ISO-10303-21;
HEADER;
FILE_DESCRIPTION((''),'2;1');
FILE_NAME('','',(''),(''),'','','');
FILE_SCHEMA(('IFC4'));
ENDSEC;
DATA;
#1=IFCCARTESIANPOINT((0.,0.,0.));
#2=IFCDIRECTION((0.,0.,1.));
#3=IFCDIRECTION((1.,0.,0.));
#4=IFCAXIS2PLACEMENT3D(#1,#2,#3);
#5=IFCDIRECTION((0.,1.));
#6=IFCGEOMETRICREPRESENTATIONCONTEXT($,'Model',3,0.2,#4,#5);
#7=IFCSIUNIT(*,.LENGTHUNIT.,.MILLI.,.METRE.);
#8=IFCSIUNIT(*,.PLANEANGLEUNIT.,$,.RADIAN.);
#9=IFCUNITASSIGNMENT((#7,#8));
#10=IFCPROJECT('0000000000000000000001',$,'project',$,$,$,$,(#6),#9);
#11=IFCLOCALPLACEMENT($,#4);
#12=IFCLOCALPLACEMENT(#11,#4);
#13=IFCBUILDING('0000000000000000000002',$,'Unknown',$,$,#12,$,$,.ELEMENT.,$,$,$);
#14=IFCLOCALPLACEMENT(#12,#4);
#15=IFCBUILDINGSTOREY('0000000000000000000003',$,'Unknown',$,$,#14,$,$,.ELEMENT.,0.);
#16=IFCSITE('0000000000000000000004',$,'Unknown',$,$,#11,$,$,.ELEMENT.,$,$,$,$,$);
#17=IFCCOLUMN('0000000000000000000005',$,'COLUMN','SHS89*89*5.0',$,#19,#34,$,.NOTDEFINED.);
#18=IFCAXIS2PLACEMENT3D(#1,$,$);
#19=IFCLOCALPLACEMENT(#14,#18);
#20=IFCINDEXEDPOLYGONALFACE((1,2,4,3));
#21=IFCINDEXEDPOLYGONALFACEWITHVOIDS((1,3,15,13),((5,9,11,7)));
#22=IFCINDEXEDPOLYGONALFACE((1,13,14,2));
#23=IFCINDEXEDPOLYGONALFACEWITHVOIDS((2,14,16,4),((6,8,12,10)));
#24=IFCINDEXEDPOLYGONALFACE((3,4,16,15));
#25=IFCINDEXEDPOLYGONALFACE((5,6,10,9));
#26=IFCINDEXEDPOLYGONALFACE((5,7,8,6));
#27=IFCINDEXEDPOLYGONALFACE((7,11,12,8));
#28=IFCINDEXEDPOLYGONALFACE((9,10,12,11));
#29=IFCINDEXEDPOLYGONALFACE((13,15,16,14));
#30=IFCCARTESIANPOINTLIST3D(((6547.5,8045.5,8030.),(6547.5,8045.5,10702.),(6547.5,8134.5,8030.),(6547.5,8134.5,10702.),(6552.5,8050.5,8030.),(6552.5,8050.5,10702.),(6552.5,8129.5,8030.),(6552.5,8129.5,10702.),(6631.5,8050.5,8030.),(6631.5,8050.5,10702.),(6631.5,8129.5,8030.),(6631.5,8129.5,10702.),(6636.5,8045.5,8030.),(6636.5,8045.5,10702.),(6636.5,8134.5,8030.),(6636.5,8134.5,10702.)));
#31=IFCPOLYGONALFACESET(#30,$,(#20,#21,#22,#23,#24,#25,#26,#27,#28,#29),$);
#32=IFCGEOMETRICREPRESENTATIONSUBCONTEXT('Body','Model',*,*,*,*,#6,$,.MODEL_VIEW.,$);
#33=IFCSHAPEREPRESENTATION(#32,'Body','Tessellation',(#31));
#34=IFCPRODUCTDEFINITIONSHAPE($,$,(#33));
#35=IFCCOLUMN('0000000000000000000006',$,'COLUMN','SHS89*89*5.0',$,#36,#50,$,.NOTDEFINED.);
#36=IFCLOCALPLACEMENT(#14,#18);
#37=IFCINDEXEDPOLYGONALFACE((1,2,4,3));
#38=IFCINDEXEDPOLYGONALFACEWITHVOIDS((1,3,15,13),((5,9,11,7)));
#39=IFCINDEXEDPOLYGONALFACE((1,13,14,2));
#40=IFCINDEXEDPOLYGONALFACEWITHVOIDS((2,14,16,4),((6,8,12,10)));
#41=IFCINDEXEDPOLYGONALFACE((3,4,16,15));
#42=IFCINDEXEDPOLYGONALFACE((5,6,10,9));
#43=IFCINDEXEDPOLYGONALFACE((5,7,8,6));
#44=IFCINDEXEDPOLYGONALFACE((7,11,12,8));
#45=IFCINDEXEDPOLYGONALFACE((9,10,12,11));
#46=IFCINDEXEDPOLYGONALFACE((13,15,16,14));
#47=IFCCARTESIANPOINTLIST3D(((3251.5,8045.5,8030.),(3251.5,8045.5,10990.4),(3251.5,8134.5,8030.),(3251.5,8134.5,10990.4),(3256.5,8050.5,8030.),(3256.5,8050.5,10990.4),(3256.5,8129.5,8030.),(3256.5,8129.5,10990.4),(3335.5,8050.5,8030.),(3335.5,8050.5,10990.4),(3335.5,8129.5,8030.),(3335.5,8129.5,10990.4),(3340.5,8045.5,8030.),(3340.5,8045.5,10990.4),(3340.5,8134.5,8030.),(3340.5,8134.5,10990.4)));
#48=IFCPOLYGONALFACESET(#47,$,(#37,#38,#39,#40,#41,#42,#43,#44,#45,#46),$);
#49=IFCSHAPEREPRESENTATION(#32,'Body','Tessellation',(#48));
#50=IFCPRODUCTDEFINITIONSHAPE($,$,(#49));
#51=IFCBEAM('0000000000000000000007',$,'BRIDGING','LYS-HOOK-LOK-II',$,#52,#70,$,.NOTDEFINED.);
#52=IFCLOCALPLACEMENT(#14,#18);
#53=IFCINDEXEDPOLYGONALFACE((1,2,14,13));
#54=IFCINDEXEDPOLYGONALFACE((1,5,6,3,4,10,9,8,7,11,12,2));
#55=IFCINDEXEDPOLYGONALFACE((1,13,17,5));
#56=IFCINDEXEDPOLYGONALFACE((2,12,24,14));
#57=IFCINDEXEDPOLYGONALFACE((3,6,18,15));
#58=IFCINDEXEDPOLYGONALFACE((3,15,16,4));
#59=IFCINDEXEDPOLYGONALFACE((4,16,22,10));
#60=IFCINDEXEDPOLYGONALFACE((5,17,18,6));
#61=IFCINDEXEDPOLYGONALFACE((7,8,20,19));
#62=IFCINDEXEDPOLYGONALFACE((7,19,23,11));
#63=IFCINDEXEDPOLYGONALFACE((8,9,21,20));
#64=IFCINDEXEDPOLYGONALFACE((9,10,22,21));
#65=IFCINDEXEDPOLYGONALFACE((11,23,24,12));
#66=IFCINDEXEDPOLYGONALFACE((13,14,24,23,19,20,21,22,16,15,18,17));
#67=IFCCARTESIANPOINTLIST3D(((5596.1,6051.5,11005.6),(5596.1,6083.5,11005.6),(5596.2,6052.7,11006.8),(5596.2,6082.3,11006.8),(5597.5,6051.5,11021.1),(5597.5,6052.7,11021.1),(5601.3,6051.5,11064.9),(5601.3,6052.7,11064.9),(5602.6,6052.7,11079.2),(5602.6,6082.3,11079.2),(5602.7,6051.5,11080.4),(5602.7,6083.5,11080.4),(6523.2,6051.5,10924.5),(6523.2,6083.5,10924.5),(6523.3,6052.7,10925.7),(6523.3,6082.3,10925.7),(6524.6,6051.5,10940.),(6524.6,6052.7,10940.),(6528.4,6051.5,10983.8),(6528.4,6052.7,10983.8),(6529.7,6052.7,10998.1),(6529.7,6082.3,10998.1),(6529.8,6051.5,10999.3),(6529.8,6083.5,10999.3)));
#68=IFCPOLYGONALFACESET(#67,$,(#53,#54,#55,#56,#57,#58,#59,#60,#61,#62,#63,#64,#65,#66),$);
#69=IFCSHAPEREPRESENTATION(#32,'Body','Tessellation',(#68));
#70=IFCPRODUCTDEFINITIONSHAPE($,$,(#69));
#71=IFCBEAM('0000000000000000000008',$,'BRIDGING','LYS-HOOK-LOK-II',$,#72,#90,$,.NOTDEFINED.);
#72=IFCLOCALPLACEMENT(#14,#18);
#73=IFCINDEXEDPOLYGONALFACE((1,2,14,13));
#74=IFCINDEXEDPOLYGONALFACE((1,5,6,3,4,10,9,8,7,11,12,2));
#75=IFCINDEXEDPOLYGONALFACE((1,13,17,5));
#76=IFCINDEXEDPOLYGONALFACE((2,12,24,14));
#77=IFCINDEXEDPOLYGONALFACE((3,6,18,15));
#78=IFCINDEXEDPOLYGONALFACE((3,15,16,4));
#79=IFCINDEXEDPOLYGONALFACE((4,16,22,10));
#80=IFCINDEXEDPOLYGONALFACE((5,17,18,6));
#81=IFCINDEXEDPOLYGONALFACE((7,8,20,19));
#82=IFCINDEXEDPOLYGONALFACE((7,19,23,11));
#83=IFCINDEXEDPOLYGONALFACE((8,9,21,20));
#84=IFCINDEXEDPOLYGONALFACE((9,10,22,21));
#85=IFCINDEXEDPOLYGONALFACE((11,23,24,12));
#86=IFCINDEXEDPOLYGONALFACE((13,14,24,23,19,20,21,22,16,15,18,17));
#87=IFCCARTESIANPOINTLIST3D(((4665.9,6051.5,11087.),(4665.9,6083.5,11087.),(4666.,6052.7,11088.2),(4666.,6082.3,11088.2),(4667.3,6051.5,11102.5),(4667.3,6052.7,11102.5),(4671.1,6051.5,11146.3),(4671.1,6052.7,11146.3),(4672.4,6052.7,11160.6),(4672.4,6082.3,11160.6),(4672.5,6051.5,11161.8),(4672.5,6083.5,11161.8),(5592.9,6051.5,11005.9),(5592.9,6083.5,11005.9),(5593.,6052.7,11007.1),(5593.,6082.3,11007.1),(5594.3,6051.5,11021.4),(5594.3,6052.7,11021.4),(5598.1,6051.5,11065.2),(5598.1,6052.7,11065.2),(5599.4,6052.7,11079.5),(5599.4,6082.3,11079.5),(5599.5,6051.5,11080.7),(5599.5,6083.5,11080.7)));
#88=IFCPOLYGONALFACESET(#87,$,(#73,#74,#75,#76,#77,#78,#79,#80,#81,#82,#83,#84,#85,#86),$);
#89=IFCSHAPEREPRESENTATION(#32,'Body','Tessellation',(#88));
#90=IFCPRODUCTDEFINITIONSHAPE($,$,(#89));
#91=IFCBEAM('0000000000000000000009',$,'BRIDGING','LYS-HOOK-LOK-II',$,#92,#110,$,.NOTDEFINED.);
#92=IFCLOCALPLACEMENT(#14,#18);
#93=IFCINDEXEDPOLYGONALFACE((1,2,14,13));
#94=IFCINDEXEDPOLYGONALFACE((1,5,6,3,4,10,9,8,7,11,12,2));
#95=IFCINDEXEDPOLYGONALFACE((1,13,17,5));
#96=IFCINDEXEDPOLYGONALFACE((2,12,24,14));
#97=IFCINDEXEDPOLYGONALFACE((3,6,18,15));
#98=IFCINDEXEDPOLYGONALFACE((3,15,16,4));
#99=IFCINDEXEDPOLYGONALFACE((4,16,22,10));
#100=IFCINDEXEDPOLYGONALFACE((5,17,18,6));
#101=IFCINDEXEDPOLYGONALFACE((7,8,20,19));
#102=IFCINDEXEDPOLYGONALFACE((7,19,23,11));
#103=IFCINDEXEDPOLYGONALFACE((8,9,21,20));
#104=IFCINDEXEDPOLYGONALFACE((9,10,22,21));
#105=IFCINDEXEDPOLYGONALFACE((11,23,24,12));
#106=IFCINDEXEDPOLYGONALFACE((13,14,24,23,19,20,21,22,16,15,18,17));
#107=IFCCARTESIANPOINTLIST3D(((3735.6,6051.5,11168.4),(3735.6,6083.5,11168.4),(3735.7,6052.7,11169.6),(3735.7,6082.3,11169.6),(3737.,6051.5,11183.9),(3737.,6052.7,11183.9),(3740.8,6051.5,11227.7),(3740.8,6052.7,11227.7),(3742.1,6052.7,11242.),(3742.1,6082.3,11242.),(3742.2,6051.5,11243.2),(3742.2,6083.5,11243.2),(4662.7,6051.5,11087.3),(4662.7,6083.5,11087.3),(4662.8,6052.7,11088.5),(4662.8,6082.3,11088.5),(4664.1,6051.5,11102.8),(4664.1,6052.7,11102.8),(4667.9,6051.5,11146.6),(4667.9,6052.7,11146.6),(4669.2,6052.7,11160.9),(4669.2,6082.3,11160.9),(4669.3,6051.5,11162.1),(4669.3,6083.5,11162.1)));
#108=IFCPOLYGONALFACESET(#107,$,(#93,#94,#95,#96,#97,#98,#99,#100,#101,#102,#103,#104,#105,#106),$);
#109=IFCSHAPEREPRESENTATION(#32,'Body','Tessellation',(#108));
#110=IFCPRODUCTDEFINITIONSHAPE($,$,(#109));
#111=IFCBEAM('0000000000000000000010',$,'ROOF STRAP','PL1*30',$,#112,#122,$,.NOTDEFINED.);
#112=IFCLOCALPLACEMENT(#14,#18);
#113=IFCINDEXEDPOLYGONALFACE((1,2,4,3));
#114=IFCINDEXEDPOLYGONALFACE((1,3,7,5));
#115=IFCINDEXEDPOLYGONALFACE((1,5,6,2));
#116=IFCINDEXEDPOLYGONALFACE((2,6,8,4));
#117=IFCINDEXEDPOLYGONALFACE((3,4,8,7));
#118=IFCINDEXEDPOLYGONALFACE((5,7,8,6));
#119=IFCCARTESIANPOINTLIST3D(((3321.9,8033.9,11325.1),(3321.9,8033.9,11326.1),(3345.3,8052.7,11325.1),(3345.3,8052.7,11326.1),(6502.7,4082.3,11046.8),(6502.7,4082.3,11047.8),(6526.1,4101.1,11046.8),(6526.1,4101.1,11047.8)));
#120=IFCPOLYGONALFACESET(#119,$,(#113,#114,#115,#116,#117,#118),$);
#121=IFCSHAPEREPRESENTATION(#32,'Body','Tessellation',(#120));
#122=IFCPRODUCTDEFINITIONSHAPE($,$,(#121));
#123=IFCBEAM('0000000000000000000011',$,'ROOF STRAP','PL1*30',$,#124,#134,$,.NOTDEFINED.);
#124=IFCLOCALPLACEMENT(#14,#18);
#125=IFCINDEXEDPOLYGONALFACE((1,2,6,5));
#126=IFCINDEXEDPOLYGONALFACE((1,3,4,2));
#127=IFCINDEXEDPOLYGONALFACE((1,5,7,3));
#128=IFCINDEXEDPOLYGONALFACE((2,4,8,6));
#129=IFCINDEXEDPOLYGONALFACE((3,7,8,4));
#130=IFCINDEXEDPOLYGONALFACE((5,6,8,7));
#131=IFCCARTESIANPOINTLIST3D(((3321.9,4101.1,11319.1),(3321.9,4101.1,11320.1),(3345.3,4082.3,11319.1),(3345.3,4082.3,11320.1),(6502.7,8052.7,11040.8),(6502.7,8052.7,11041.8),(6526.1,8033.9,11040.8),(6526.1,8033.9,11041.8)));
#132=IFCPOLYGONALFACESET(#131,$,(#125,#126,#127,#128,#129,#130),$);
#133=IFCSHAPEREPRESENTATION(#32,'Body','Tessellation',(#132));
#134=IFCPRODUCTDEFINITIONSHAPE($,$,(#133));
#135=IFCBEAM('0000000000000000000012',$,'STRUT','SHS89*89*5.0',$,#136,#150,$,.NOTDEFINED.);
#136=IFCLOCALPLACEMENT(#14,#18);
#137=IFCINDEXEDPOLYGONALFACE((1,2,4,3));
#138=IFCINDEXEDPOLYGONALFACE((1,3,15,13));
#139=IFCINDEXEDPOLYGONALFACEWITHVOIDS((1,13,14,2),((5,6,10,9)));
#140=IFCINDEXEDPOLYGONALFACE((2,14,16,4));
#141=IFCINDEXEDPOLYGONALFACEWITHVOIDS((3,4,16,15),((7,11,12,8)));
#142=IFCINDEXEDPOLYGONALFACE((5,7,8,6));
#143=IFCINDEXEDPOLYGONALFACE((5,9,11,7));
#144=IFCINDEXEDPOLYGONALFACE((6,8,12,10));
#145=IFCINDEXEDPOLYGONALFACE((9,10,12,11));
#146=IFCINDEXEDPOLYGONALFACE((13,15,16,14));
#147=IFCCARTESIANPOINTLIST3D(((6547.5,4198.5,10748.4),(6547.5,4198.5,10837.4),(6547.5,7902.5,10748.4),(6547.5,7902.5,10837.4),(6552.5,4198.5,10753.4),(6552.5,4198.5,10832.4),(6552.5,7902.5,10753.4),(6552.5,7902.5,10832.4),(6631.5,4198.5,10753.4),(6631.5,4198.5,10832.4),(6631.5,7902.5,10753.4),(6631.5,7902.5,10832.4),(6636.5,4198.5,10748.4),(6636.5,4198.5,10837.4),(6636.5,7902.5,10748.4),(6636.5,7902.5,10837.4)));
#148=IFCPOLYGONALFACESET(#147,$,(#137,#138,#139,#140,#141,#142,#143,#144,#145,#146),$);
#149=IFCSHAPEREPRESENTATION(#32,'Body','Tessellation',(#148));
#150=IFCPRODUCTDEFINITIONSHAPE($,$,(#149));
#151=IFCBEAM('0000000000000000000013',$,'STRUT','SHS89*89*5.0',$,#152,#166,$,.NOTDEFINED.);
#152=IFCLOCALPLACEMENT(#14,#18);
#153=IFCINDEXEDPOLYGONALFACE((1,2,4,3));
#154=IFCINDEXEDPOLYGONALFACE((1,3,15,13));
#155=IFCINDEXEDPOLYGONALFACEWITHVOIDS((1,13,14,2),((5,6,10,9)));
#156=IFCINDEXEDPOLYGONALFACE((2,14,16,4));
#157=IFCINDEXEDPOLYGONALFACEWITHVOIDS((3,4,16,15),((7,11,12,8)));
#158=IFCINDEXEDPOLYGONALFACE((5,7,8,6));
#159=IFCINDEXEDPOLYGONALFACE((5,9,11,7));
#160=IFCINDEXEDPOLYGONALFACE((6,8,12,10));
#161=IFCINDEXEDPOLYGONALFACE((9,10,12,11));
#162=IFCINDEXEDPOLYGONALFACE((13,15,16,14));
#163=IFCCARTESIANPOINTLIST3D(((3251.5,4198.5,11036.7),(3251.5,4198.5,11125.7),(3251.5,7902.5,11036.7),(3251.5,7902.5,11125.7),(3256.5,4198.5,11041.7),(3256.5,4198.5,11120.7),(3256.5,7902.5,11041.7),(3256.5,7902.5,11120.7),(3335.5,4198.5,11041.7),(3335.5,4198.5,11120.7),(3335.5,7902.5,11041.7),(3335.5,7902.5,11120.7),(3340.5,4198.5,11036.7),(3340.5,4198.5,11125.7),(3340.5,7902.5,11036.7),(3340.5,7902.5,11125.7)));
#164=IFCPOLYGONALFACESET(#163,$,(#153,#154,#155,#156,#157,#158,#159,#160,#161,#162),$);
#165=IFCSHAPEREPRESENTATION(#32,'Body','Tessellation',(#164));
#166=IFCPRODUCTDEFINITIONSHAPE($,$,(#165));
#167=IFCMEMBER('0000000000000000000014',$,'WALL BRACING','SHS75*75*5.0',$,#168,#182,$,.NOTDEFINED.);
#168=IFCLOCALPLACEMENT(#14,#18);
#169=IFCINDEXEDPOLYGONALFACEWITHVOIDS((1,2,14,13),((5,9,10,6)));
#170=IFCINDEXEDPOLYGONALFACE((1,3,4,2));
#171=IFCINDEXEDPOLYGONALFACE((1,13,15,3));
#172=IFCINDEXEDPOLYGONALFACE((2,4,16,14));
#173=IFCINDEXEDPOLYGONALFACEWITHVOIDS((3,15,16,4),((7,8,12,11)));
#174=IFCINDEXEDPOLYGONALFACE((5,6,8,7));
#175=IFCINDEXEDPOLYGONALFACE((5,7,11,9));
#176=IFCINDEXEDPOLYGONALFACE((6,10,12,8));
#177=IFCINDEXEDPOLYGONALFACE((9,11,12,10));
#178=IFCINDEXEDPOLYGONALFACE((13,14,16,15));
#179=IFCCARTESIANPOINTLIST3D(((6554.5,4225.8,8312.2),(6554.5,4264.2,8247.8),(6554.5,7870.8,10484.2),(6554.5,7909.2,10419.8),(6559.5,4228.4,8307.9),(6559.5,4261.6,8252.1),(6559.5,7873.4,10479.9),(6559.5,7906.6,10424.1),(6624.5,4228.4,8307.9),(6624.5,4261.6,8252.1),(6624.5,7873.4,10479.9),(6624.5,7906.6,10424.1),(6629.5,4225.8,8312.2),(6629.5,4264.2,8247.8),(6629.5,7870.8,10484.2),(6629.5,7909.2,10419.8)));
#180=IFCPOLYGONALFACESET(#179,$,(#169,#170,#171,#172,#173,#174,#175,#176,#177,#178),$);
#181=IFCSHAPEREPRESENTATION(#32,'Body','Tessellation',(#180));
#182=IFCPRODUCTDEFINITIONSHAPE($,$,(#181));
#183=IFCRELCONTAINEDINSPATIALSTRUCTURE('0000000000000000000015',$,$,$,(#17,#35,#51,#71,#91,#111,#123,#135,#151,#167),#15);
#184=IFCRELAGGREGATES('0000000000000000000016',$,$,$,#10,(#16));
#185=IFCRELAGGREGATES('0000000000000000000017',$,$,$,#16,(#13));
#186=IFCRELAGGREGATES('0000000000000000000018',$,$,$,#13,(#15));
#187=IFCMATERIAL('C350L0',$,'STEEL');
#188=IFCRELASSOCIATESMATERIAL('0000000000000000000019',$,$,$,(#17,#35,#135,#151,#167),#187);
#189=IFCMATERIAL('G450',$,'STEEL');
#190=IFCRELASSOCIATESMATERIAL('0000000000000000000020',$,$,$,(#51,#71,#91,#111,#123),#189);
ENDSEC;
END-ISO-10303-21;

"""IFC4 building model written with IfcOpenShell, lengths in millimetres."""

from ifc_helpers import new_model, si_unit, direction, frame, origin_with_axes, place, context, subcontext, project, spatial, line, indexed_curve, outline, extrude, material, element, save


model = new_model("IFC4")

# Units and contexts
model_context = context("Model", 3, precision=0.2, world=origin_with_axes(), true_north=direction((0.0, 1.0)))
body_context = subcontext(model_context, "Body", "Model", "MODEL_VIEW")
ifc_project = project(units=[si_unit("LENGTHUNIT", "METRE", prefix="MILLI"), si_unit("PLANEANGLEUNIT", "RADIAN")], contexts=[model_context])

# Site, building, storey
site_placement = place(None, origin_with_axes())
site = spatial("IfcSite", under=ifc_project, at=site_placement, Name="Unknown", CompositionType="ELEMENT")
building_placement = place(site_placement, origin_with_axes())
building = spatial("IfcBuilding", under=site, at=building_placement, Name="Unknown", CompositionType="ELEMENT")
storey_placement = place(building_placement, origin_with_axes())
storey = spatial("IfcBuildingStorey", under=building, at=storey_placement, Name="Unknown", CompositionType="ELEMENT", Elevation=0.0)

# Columns
ifc_material_1 = material(Name="C350L0", Category="STEEL")
column_1_placement = place(storey_placement, frame((6592.0, 8090.0, 8030.0), z_axis=(-1.0, 0.0, 0.0), x_axis=(0.0, 0.0, 1.0)))
element("IfcColumn", 1, at=column_1_placement, inside=storey, material=ifc_material_1, Name="COLUMN", Description="SHS89*89*5.0", PredefinedType="NOTDEFINED", context=body_context, shape_type="SolidModel", body=[
    extrude(outline(indexed_curve([(-44.5, -44.5), (44.5, -44.5), (44.5, 44.5), (-44.5, 44.5)], segments=[line(1, 2, 3, 4, 1)]), holes=[indexed_curve([(-39.5, -39.5), (-39.5, 39.5), (39.5, 39.5), (39.5, -39.5)], segments=[line(1, 2, 3, 4, 1)])]), frame((0.0, 0.0, 0.0), z_axis=(-1.0, 0.0, 0.0), x_axis=(0.0, 0.0, 1.0)), (0.0, 0.0, -1.0), 2672.0),
])
column_2_placement = place(storey_placement, frame((3296.0, 8090.0, 8030.0), z_axis=(-1.0, 0.0, 0.0), x_axis=(0.0, 0.0, 1.0)))
element("IfcColumn", 2, at=column_2_placement, inside=storey, material=ifc_material_1, Name="COLUMN", Description="SHS89*89*5.0", PredefinedType="NOTDEFINED", context=body_context, shape_type="SolidModel", body=[
    extrude(outline(indexed_curve([(-44.5, -44.5), (44.5, -44.5), (44.5, 44.5), (-44.5, 44.5)], segments=[line(1, 2, 3, 4, 1)]), holes=[indexed_curve([(-39.5, -39.5), (-39.5, 39.5), (39.5, 39.5), (39.5, -39.5)], segments=[line(1, 2, 3, 4, 1)])]), frame((0.0, 0.0, 0.0), z_axis=(-1.0, 0.0, 0.0), x_axis=(0.0, 0.0, 1.0)), (0.0, 0.0, -1.0), 2960.4),
])

# Beams
ifc_material_2 = material(Name="G450", Category="STEEL")
beam_1_placement = place(storey_placement, frame((5599.4, 6067.5, 11043.0), z_axis=(0.0, -1.0, 0.0), x_axis=(0.996196, 0.0, -0.087144)))
element("IfcBeam", 3, at=beam_1_placement, inside=storey, material=ifc_material_2, Name="BRIDGING", Description="LYS-HOOK-LOK-II", PredefinedType="NOTDEFINED", context=body_context, shape_type="SolidModel", body=[
    extrude(outline(indexed_curve([(16.0, -37.5), (16.0, -22.0), (14.8, -22.0), (14.8, -36.3), (-14.8, -36.3), (-14.8, 36.3), (14.8, 36.3), (14.8, 22.0), (16.0, 22.0), (16.0, 37.5), (-16.0, 37.5), (-16.0, -37.5)], segments=[line(1, 2, 3, 4, 5, 6, 7, 8, 9, 10, 11, 12, 1)])), frame((0.0, 0.0, 0.0), z_axis=(-1.0, 0.0, 0.0), x_axis=(0.0, 0.0, 1.0)), (0.0, 0.0, -1.0), 930.6),
])
beam_2_placement = place(storey_placement, frame((4669.2, 6067.5, 11124.4), z_axis=(0.0, -1.0, 0.0), x_axis=(0.996195, 0.0, -0.087154)))
element("IfcBeam", 4, at=beam_2_placement, inside=storey, material=ifc_material_2, Name="BRIDGING", Description="LYS-HOOK-LOK-II", PredefinedType="NOTDEFINED", context=body_context, shape_type="SolidModel", body=[
    extrude(outline(indexed_curve([(16.0, -37.5), (16.0, -22.0), (14.8, -22.0), (14.8, -36.3), (-14.8, -36.3), (-14.8, 36.3), (14.8, 36.3), (14.8, 22.0), (16.0, 22.0), (16.0, 37.5), (-16.0, 37.5), (-16.0, -37.5)], segments=[line(1, 2, 3, 4, 5, 6, 7, 8, 9, 10, 11, 12, 1)])), frame((0.0, 0.0, 0.0), z_axis=(-1.0, 0.0, 0.0), x_axis=(0.0, 0.0, 1.0)), (0.0, 0.0, -1.0), 930.5),
])
beam_3_placement = place(storey_placement, frame((3738.9, 6067.5, 11205.8), z_axis=(0.0, -1.0, 0.0), x_axis=(0.996196, 0.0, -0.087144)))
element("IfcBeam", 5, at=beam_3_placement, inside=storey, material=ifc_material_2, Name="BRIDGING", Description="LYS-HOOK-LOK-II", PredefinedType="NOTDEFINED", context=body_context, shape_type="SolidModel", body=[
    extrude(outline(indexed_curve([(16.0, -37.5), (16.0, -22.0), (14.8, -22.0), (14.8, -36.3), (-14.8, -36.3), (-14.8, 36.3), (14.8, 36.3), (14.8, 22.0), (16.0, 22.0), (16.0, 37.5), (-16.0, 37.5), (-16.0, -37.5)], segments=[line(1, 2, 3, 4, 5, 6, 7, 8, 9, 10, 11, 12, 1)])), frame((0.0, 0.0, 0.0), z_axis=(-1.0, 0.0, 0.0), x_axis=(0.0, 0.0, 1.0)), (0.0, 0.0, -1.0), 930.6),
])
for number, where, z_axis, x_axis, name in (
    (6, (6514.4, 4091.7, 11047.3), (0.034349, -0.042673, 0.998498), (-0.626097, 0.777819, 0.05478), "ROOF STRAP"),
    (7, (3333.6, 4091.7, 11319.6), (0.034349, 0.042673, 0.998498), (0.626097, 0.777819, -0.05478), "ROOF STRAP"),
):
    element("IfcBeam", number, at=place(storey_placement, frame(where, z_axis=z_axis, x_axis=x_axis)), inside=storey, material=ifc_material_2, Name=name, Description="PL1*30", PredefinedType="NOTDEFINED", context=body_context, shape_type="SolidModel", body=[
        extrude(outline(indexed_curve([(-0.5, -15.0), (0.5, -15.0), (0.5, 15.0), (-0.5, 15.0)], segments=[line(1, 2, 3, 4, 1)])), frame((0.0, 0.0, 0.0), z_axis=(-1.0, 0.0, 0.0), x_axis=(0.0, 0.0, 1.0)), (0.0, 0.0, -1.0), 5080.4),
    ])
for number, where, z_axis, x_axis, name in (
    (8, (6592.0, 4198.5, 10792.9), (0.0, 0.0, 1.0), (0.0, 1.0, 0.0), "STRUT"),
    (9, (3296.0, 4198.5, 11081.2), (0.0, 0.0, 1.0), (0.0, 1.0, 0.0), "STRUT"),
):
    element("IfcBeam", number, at=place(storey_placement, frame(where, z_axis=z_axis, x_axis=x_axis)), inside=storey, material=ifc_material_1, Name=name, Description="SHS89*89*5.0", PredefinedType="NOTDEFINED", context=body_context, shape_type="SolidModel", body=[
        extrude(outline(indexed_curve([(-44.5, -44.5), (44.5, -44.5), (44.5, 44.5), (-44.5, 44.5)], segments=[line(1, 2, 3, 4, 1)]), holes=[indexed_curve([(-39.5, -39.5), (-39.5, 39.5), (39.5, 39.5), (39.5, -39.5)], segments=[line(1, 2, 3, 4, 1)])]), frame((0.0, 0.0, 0.0), z_axis=(-1.0, 0.0, 0.0), x_axis=(0.0, 0.0, 1.0)), (0.0, 0.0, -1.0), 3704.0),
    ])

# Member
member_placement = place(storey_placement, frame((6592.0, 7890.0, 10452.0), z_axis=(0.0, -0.511894, 0.859049), x_axis=(0.0, -0.859049, -0.511894)))
element("IfcMember", 10, at=member_placement, inside=storey, material=ifc_material_1, Name="WALL BRACING", Description="SHS75*75*5.0", PredefinedType="NOTDEFINED", context=body_context, shape_type="SolidModel", body=[
    extrude(outline(indexed_curve([(-37.5, -37.5), (37.5, -37.5), (37.5, 37.5), (-37.5, 37.5)], segments=[line(1, 2, 3, 4, 1)]), holes=[indexed_curve([(-32.5, -32.5), (-32.5, 32.5), (32.5, 32.5), (32.5, -32.5)], segments=[line(1, 2, 3, 4, 1)])]), frame((0.0, 0.0, 0.0), z_axis=(-1.0, 0.0, 0.0), x_axis=(0.0, 0.0, 1.0)), (0.0, 0.0, -1.0), 4243.1),
])

save(model, "model.ifc")
